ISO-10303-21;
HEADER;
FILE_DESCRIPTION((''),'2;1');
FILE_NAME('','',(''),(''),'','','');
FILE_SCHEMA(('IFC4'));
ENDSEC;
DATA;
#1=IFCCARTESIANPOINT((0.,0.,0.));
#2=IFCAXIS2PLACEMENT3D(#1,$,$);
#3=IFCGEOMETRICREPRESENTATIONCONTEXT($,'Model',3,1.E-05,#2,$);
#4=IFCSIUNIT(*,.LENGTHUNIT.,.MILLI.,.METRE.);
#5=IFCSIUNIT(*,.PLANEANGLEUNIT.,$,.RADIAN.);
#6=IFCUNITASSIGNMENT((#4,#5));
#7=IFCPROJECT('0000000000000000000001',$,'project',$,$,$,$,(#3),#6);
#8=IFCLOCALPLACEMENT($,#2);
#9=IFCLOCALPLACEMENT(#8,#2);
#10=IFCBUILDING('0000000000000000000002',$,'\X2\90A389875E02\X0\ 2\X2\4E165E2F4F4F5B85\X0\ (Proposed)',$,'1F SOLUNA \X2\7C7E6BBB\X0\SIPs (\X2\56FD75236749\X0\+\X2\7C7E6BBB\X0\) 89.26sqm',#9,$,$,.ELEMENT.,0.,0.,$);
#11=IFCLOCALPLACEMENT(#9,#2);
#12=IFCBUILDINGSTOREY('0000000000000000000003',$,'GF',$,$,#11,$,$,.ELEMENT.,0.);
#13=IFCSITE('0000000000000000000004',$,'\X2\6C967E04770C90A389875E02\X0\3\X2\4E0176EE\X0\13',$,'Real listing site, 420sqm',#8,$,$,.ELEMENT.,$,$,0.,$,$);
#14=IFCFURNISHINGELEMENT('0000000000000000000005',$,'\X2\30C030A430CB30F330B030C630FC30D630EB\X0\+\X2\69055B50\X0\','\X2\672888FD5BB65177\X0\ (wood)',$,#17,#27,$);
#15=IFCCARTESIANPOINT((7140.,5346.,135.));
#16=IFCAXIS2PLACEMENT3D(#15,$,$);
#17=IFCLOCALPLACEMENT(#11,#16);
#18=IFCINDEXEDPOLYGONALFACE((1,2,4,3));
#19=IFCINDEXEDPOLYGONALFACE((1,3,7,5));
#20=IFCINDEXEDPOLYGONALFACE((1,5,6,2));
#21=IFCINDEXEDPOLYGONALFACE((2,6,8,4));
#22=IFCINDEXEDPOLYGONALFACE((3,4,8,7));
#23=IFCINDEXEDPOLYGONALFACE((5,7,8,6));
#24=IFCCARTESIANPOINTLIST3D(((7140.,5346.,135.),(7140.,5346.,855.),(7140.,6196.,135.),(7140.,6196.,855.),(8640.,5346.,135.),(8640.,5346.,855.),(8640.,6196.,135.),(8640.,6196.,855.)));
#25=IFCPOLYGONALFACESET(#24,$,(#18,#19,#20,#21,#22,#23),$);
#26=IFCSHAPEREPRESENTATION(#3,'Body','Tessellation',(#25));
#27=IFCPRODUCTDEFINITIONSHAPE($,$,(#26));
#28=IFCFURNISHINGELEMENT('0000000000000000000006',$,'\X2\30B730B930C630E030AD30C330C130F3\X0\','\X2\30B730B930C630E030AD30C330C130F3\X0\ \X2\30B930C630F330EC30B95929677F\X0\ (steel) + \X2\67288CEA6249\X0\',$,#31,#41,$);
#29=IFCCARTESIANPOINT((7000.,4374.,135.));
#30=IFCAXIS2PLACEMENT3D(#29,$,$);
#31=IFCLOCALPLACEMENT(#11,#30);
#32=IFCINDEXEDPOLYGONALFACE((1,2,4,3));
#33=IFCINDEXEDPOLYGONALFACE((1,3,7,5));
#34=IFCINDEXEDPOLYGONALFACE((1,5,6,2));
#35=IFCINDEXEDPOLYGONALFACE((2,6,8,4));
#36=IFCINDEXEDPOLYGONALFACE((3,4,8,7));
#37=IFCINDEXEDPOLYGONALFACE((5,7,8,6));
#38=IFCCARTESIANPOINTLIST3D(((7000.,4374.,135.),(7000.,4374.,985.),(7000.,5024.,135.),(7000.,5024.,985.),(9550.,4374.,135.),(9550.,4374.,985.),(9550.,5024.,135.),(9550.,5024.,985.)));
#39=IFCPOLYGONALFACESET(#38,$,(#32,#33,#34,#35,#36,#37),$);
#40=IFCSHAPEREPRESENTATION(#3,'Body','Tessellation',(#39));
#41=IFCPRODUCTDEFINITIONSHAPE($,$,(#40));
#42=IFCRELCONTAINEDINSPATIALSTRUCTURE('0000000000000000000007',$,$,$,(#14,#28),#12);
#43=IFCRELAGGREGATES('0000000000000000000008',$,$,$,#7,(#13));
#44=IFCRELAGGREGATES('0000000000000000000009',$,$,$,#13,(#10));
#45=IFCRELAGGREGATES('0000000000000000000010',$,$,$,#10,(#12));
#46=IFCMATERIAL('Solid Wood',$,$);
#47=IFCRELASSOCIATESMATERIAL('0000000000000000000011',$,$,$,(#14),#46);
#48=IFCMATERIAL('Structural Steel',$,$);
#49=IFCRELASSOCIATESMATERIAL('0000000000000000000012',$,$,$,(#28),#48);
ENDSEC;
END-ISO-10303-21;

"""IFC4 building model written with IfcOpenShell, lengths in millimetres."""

from ifc_helpers import new_model, si_unit, frame, frame_2d, origin, place, context, project, spatial, rectangle, extrude, material, element, save


model = new_model("IFC4")

# Units and contexts
model_context = context("Model", 3, precision=1e-05, world=origin())
ifc_project = project(units=[si_unit("LENGTHUNIT", "METRE", prefix="MILLI"), si_unit("PLANEANGLEUNIT", "RADIAN")], contexts=[model_context])

# Site, building, storey
site_placement = place(None, origin())
site = spatial("IfcSite", under=ifc_project, at=site_placement, Name="沖縄県那覇市3丁目13", ObjectType="Real listing site, 420sqm", CompositionType="ELEMENT", RefElevation=0.0)
building_placement = place(site_placement, origin())
building = spatial("IfcBuilding", under=site, at=building_placement, Name="那覇市 2世帯住宅 (Proposed)", ObjectType="1F SOLUNA 籾殻SIPs (国産杉+籾殻) 89.26sqm", CompositionType="ELEMENT", ElevationOfRefHeight=0.0, ElevationOfTerrain=0.0)
storey_placement = place(building_placement, origin())
storey = spatial("IfcBuildingStorey", under=building, at=storey_placement, Name="GF", CompositionType="ELEMENT", Elevation=0.0)

# Shared definitions
ifc_material_1 = material(Name="Solid Wood")

# Shared definitions
ifc_material_2 = material(Name="Structural Steel")

# Furnishing elements
furnishing_1_placement = place(storey_placement, frame((7140.0, 5346.0, 135.0)))
element("IfcFurnishingElement", 1, at=furnishing_1_placement, inside=storey, material=ifc_material_1, Name="ダイニングテーブル+椅子", Description="木製家具 (wood)", context=model_context, shape_type="SweptSolid", body=[
    extrude(rectangle(XDim=1500.0, YDim=850.0, at=frame_2d((750.0, 425.0))), frame((7140.0, 5346.0, 135.0)), (0.0, 0.0, 1.0), 720.0),
])
furnishing_2_placement = place(storey_placement, frame((7000.0, 4374.0, 135.0)))
element("IfcFurnishingElement", 2, at=furnishing_2_placement, inside=storey, material=ifc_material_2, Name="システムキッチン", Description="システムキッチン ステンレス天板 (steel) + 木質扉", context=model_context, shape_type="SweptSolid", body=[
    extrude(rectangle(XDim=2550.0, YDim=650.0, at=frame_2d((1275.0, 325.0))), frame((7000.0, 4374.0, 135.0)), (0.0, 0.0, 1.0), 850.0),
])

save(model, "model.ifc")
